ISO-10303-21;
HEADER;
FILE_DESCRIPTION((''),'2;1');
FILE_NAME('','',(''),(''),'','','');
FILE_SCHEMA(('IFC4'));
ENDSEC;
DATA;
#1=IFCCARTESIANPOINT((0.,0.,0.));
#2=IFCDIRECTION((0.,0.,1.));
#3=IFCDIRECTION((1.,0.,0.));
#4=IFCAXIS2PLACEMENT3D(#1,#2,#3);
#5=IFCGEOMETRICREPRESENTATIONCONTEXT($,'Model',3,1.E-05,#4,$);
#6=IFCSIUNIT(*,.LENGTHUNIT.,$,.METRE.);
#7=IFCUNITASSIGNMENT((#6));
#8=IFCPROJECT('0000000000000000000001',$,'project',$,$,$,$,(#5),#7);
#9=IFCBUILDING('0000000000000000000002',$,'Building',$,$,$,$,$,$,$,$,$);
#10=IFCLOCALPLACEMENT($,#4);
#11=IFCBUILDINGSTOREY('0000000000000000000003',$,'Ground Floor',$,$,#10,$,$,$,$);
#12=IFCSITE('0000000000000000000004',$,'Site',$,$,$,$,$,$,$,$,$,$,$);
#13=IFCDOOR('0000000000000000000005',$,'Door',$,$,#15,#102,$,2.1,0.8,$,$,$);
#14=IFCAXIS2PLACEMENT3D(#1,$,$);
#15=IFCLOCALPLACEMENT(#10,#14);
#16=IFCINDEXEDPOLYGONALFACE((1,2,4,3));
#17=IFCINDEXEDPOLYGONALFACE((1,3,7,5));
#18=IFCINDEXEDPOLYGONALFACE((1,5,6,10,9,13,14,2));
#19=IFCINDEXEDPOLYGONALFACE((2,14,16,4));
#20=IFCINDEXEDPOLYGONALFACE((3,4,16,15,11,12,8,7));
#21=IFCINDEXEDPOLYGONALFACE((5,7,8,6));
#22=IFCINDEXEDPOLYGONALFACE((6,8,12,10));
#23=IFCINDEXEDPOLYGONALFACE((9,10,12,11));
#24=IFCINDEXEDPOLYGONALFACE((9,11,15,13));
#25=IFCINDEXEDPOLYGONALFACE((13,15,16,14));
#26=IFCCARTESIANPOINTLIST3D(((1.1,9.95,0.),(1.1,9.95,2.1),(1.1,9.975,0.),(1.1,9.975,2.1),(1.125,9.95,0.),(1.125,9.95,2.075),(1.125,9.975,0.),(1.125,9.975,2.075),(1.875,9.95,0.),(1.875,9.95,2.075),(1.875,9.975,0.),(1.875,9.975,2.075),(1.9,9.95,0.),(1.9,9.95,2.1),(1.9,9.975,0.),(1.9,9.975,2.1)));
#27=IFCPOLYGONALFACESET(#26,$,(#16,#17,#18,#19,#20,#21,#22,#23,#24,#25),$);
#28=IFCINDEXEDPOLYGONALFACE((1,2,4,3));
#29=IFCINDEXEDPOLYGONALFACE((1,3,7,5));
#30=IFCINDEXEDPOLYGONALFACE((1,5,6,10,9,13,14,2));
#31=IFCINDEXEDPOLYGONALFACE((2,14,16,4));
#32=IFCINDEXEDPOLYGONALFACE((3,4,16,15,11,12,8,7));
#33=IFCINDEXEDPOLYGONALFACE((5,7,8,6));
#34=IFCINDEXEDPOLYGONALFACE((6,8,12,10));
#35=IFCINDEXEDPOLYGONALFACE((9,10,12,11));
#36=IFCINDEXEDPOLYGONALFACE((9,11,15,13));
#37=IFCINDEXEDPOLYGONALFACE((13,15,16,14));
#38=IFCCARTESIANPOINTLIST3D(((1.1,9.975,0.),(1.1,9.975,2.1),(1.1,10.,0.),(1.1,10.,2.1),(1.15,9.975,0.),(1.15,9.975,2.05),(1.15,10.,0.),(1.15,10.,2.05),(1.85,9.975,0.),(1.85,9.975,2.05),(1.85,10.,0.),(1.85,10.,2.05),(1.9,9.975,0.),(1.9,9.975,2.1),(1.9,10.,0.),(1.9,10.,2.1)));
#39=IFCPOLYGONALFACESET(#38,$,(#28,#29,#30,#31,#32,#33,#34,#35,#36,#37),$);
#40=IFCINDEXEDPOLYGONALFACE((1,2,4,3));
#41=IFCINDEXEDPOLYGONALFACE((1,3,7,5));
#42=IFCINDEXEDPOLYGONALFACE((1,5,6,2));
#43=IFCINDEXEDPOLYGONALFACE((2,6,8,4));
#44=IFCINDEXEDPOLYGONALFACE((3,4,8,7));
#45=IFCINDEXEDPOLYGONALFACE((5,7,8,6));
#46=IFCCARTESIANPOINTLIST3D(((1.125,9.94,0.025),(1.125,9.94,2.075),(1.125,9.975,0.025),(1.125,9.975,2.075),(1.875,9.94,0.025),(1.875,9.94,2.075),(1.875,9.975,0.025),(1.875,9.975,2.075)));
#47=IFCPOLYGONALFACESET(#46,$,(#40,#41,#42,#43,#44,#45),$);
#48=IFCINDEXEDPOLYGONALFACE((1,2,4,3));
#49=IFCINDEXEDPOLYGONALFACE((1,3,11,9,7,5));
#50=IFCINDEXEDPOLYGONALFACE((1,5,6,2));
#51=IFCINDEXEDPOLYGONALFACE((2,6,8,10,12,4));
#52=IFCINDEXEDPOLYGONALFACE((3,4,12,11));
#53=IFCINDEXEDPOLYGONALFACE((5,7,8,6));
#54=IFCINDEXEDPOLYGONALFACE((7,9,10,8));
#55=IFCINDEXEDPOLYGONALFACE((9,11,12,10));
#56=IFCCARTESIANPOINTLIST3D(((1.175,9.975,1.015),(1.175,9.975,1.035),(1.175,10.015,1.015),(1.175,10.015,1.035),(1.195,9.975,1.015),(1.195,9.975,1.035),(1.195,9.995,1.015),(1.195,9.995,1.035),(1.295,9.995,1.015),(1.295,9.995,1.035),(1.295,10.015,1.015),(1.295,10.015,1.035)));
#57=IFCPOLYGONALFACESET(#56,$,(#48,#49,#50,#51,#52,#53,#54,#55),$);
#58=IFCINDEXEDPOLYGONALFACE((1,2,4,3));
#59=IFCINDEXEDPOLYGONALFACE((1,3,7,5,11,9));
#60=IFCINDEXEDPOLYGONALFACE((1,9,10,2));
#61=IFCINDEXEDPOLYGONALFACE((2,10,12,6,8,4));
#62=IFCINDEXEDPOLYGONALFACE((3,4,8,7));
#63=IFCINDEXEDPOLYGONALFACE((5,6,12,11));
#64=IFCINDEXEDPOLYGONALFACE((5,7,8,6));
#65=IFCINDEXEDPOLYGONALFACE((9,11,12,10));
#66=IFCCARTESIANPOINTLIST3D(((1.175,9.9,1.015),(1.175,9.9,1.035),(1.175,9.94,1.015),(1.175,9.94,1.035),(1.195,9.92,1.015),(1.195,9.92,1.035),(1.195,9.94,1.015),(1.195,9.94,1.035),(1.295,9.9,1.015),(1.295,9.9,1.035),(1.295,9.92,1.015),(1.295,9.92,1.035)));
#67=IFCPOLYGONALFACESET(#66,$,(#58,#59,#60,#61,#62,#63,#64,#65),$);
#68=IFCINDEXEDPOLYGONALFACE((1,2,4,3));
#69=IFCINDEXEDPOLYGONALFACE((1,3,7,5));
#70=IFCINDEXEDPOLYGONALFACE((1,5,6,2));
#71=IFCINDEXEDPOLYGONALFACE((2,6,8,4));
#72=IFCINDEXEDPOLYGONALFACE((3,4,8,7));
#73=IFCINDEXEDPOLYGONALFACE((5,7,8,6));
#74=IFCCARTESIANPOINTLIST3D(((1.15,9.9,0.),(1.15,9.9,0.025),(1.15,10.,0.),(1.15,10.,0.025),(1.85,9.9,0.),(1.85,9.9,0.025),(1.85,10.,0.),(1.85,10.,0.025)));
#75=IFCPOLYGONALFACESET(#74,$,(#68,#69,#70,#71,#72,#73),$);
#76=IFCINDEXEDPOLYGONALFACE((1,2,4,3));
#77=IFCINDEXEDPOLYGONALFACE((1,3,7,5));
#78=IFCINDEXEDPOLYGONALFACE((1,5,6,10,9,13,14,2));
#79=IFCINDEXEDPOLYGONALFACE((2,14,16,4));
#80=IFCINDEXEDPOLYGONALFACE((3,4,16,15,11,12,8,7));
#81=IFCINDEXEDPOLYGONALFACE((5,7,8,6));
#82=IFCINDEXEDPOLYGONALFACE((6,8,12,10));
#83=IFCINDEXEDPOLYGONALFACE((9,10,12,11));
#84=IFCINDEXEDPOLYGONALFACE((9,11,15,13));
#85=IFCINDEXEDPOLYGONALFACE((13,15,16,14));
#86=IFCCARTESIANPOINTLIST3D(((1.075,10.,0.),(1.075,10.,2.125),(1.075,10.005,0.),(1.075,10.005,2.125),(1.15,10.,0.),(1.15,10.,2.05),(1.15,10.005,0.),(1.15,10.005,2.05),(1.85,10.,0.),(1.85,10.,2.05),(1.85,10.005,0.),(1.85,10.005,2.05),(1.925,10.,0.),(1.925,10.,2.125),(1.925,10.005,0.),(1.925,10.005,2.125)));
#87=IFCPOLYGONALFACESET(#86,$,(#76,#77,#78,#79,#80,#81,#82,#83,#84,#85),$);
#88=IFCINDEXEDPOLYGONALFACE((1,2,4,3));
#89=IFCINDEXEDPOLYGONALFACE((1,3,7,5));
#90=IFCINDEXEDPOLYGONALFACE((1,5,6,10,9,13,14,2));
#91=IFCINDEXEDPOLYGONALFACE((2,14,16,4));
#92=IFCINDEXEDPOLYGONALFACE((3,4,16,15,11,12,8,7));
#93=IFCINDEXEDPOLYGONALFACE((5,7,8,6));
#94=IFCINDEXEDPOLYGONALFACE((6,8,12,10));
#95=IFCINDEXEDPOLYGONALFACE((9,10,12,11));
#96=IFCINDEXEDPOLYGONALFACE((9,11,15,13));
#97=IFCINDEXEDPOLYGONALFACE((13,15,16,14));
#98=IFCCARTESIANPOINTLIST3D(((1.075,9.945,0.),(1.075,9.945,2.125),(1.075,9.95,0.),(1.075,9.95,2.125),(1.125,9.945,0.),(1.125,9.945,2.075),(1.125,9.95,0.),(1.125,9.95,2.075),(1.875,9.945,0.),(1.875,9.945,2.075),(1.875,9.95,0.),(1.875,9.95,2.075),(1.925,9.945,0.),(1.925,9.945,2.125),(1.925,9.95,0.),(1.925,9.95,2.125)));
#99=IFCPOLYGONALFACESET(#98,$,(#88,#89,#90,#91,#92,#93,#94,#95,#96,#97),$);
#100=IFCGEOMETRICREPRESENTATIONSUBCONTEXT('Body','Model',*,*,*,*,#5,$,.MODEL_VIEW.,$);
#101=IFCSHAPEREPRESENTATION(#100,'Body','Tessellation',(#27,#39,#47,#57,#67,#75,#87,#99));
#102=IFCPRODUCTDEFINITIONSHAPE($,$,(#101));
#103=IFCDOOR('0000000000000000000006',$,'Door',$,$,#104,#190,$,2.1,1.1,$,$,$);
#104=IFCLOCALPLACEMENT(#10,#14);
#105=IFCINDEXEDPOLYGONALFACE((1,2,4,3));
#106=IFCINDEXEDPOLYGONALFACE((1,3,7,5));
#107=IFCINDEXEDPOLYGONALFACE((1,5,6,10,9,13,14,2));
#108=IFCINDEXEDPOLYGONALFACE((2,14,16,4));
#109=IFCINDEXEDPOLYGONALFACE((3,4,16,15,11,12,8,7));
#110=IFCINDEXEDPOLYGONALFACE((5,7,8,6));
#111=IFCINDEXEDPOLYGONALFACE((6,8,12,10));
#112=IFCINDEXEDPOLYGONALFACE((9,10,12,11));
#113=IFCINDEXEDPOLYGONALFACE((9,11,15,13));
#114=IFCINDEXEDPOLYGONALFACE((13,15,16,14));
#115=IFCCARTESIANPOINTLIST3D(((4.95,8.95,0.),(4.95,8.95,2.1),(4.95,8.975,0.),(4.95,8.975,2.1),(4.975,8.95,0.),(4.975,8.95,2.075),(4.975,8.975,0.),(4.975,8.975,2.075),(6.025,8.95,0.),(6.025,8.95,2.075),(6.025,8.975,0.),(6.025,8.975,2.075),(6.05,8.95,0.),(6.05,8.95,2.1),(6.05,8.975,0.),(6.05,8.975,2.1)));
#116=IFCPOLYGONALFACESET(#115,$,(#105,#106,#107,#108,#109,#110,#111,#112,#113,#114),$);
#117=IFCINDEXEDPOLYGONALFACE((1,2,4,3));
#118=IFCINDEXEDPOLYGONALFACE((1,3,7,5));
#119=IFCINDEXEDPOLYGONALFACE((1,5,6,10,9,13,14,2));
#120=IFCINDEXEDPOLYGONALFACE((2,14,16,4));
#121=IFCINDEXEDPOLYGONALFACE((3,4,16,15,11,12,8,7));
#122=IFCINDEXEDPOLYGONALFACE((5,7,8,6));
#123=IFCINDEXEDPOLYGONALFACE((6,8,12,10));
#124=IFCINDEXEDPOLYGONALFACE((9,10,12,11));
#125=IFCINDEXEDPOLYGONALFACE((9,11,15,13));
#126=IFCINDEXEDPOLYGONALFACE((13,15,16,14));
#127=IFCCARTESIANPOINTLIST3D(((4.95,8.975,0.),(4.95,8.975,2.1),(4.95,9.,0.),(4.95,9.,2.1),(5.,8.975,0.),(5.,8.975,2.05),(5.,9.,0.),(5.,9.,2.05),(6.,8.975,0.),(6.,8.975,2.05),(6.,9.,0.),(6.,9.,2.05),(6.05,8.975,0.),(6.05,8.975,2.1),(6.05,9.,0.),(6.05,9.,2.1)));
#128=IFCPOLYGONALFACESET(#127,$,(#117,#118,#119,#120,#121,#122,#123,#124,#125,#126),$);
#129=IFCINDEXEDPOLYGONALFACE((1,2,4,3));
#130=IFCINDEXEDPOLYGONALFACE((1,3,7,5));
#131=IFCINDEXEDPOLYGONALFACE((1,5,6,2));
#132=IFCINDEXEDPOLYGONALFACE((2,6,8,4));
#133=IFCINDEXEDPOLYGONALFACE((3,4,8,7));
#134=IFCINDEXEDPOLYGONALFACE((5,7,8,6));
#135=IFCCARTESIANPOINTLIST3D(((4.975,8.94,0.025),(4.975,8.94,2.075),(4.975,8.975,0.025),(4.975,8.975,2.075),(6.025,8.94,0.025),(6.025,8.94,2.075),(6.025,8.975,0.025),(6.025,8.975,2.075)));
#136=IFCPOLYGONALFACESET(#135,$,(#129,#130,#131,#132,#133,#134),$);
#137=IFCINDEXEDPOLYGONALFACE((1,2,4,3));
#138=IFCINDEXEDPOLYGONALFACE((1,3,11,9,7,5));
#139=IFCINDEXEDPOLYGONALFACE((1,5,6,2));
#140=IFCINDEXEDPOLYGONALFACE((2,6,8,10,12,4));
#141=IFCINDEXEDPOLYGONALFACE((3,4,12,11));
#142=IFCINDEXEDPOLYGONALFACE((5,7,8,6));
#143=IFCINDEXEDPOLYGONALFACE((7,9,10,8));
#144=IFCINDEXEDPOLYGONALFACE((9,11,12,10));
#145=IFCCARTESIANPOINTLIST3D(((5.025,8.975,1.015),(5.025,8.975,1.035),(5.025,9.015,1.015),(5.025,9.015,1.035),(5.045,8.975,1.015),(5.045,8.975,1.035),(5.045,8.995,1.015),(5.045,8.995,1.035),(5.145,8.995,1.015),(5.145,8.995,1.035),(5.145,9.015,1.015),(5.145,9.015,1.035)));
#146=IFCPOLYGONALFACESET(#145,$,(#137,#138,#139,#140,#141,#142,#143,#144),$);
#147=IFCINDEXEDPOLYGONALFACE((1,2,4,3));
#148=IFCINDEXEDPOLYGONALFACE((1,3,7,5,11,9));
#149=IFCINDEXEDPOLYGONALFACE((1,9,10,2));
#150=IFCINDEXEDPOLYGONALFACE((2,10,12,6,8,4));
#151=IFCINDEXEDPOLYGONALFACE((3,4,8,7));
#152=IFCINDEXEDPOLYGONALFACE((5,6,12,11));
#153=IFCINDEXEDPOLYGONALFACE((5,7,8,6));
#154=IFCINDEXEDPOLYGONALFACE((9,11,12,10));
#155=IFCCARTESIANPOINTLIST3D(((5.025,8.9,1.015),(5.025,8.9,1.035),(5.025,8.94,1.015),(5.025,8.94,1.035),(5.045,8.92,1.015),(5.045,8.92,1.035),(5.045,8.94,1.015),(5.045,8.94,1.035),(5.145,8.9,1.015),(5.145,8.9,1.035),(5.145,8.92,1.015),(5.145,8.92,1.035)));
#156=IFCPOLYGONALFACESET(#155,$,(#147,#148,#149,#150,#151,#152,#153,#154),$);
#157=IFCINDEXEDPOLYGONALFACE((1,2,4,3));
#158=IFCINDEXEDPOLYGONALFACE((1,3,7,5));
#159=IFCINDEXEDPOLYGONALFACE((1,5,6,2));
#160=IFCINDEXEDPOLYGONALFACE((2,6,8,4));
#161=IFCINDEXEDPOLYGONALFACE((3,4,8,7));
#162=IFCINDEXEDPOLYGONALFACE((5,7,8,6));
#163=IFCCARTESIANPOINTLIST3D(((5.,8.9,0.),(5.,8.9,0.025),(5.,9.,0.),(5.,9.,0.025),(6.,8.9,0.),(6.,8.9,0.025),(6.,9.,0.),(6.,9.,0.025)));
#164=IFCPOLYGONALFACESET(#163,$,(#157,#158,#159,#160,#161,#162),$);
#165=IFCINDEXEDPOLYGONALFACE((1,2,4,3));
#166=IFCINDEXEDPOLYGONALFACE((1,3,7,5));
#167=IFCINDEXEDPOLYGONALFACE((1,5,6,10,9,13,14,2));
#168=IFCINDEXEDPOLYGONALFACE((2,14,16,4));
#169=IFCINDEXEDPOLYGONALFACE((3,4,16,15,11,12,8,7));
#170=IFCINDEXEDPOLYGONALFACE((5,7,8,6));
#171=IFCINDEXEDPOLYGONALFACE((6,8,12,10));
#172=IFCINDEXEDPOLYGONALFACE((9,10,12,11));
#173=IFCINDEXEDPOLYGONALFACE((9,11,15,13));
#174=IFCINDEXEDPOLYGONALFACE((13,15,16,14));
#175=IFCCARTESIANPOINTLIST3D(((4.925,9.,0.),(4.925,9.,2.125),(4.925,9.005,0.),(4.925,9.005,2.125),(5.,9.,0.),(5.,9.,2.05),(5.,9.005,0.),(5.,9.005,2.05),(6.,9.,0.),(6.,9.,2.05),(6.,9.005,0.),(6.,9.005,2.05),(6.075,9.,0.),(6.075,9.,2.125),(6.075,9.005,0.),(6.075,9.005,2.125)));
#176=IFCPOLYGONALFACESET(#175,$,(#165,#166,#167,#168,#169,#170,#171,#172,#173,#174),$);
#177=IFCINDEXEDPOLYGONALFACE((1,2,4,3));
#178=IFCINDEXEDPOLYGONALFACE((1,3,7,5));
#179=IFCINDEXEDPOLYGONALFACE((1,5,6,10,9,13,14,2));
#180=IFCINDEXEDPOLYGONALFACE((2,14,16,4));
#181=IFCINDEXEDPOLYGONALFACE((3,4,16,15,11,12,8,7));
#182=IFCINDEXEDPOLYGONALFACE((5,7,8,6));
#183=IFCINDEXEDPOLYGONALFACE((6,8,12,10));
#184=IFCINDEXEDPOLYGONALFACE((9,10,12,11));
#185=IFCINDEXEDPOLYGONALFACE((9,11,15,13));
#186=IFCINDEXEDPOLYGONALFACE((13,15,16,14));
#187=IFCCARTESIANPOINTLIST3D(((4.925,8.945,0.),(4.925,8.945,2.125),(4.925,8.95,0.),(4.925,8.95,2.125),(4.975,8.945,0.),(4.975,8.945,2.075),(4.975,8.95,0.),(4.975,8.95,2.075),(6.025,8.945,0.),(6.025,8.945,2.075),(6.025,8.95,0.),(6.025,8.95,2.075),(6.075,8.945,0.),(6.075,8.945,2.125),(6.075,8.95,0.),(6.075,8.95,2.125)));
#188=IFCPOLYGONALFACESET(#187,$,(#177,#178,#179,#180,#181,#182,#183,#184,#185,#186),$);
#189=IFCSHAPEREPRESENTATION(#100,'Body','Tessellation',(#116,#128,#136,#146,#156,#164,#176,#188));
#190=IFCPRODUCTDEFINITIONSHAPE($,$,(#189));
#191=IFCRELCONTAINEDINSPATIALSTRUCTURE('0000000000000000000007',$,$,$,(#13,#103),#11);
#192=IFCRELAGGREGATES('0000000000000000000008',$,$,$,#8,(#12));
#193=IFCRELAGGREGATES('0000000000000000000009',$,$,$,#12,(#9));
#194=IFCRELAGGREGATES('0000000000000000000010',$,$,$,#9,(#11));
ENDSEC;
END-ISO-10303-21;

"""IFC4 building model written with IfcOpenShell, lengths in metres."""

from ifc_helpers import new_model, si_unit, frame, origin_with_axes, place, context, subcontext, project, spatial, line, indexed_curve, outline, extrude, element, save


model = new_model("IFC4")

# Units and contexts
model_context = context("Model", 3, precision=1e-05, world=origin_with_axes())
body_context = subcontext(model_context, "Body", "Model", "MODEL_VIEW")
ifc_project = project(units=[si_unit("LENGTHUNIT", "METRE")], contexts=[model_context])

# Site, building, storey
site = spatial("IfcSite", under=ifc_project, Name="Site")
building = spatial("IfcBuilding", under=site, Name="Building")
storey_placement = place(None, origin_with_axes())
storey = spatial("IfcBuildingStorey", under=building, at=storey_placement, Name="Ground Floor")

# Doors
door_1_placement = place(storey_placement, frame((1.9, 10.0, 0.0), z_axis=(0.0, 0.0, 1.0), x_axis=(-1.0, 0.0, 0.0)))
element("IfcDoor", 1, at=door_1_placement, inside=storey, Name="Door", OverallHeight=2.1, OverallWidth=0.8, context=body_context, shape_type="SweptSolid", body=[
    extrude(outline(indexed_curve([(0.0, 0.0), (0.0, 2.1), (0.8, 2.1), (0.8, 0.0), (0.775, 0.0), (0.775, 2.075), (0.025, 2.075), (0.025, 0.0)], segments=[line(1, 2, 3, 4, 5, 6, 7, 8, 1)])), frame((0.0, 0.025, 0.0), z_axis=(0.0, -1.0, 0.0), x_axis=(1.0, 0.0, 0.0)), (0.0, 0.0, -1.0), 0.025),
    extrude(outline(indexed_curve([(0.0, 0.0), (0.0, 2.1), (0.8, 2.1), (0.8, 0.0), (0.75, 0.0), (0.75, 2.05), (0.05, 2.05), (0.05, 0.0)], segments=[line(1, 2, 3, 4, 5, 6, 7, 8, 1)])), frame((0.0, 0.0, 0.0), z_axis=(0.0, -1.0, 0.0), x_axis=(1.0, 0.0, 0.0)), (0.0, 0.0, -1.0), 0.025),
    extrude(outline(indexed_curve([(0.0, 0.0), (0.75, 0.0), (0.75, 0.035), (0.0, 0.035)], segments=[line(1, 2, 3, 4, 1)])), frame((0.025, 0.025, 0.025), z_axis=(0.0, 0.0, 1.0), x_axis=(1.0, 0.0, 0.0)), (0.0, 0.0, 1.0), 2.05),
    extrude(outline(indexed_curve([(0.0, 0.0), (0.0, -0.04), (-0.12, -0.04), (-0.12, -0.02), (-0.02, -0.02), (-0.02, 0.0)], segments=[line(1, 2, 3, 4, 5, 6, 1)])), frame((0.725, 0.025, 1.015), z_axis=(0.0, 0.0, 1.0), x_axis=(1.0, 0.0, 0.0)), (0.0, 0.0, 1.0), 0.02),
    extrude(outline(indexed_curve([(0.0, 0.0), (0.0, 0.04), (-0.12, 0.04), (-0.12, 0.02), (-0.02, 0.02), (-0.02, 0.0)], segments=[line(1, 2, 3, 4, 5, 6, 1)])), frame((0.725, 0.06, 1.015), z_axis=(0.0, 0.0, 1.0), x_axis=(1.0, 0.0, 0.0)), (0.0, 0.0, 1.0), 0.02),
    extrude(outline(indexed_curve([(0.0, 0.0), (0.7, 0.0), (0.7, 0.1), (0.0, 0.1)], segments=[line(1, 2, 3, 4, 1)])), frame((0.05, 0.0, 0.0), z_axis=(0.0, 0.0, 1.0), x_axis=(1.0, 0.0, 0.0)), (0.0, 0.0, 1.0), 0.025),
    extrude(outline(indexed_curve([(0.0, 0.0), (0.0, 2.125), (0.85, 2.125), (0.85, 0.0), (0.775, 0.0), (0.775, 2.05), (0.075, 2.05), (0.075, 0.0)], segments=[line(1, 2, 3, 4, 5, 6, 7, 8, 1)])), frame((-0.025, -0.005, 0.0), z_axis=(0.0, -1.0, 0.0), x_axis=(1.0, 0.0, 0.0)), (0.0, 0.0, -1.0), 0.005),
    extrude(outline(indexed_curve([(0.0, 0.0), (0.0, 2.125), (0.85, 2.125), (0.85, 0.0), (0.8, 0.0), (0.8, 2.075), (0.05, 2.075), (0.05, 0.0)], segments=[line(1, 2, 3, 4, 5, 6, 7, 8, 1)])), frame((-0.025, 0.05, 0.0), z_axis=(0.0, -1.0, 0.0), x_axis=(1.0, 0.0, 0.0)), (0.0, 0.0, -1.0), 0.005),
])
door_2_placement = place(storey_placement, frame((6.05, 9.0, 0.0), z_axis=(0.0, 0.0, 1.0), x_axis=(-1.0, 0.0, 0.0)))
element("IfcDoor", 2, at=door_2_placement, inside=storey, Name="Door", OverallHeight=2.1, OverallWidth=1.1, context=body_context, shape_type="SweptSolid", body=[
    extrude(outline(indexed_curve([(0.0, 0.0), (0.0, 2.1), (1.1, 2.1), (1.1, 0.0), (1.075, 0.0), (1.075, 2.075), (0.025, 2.075), (0.025, 0.0)], segments=[line(1, 2, 3, 4, 5, 6, 7, 8, 1)])), frame((0.0, 0.025, 0.0), z_axis=(0.0, -1.0, 0.0), x_axis=(1.0, 0.0, 0.0)), (0.0, 0.0, -1.0), 0.025),
    extrude(outline(indexed_curve([(0.0, 0.0), (0.0, 2.1), (1.1, 2.1), (1.1, 0.0), (1.05, 0.0), (1.05, 2.05), (0.05, 2.05), (0.05, 0.0)], segments=[line(1, 2, 3, 4, 5, 6, 7, 8, 1)])), frame((0.0, 0.0, 0.0), z_axis=(0.0, -1.0, 0.0), x_axis=(1.0, 0.0, 0.0)), (0.0, 0.0, -1.0), 0.025),
    extrude(outline(indexed_curve([(0.0, 0.0), (1.05, 0.0), (1.05, 0.035), (0.0, 0.035)], segments=[line(1, 2, 3, 4, 1)])), frame((0.025, 0.025, 0.025), z_axis=(0.0, 0.0, 1.0), x_axis=(1.0, 0.0, 0.0)), (0.0, 0.0, 1.0), 2.05),
    extrude(outline(indexed_curve([(0.0, 0.0), (0.0, -0.04), (-0.12, -0.04), (-0.12, -0.02), (-0.02, -0.02), (-0.02, 0.0)], segments=[line(1, 2, 3, 4, 5, 6, 1)])), frame((1.025, 0.025, 1.015), z_axis=(0.0, 0.0, 1.0), x_axis=(1.0, 0.0, 0.0)), (0.0, 0.0, 1.0), 0.02),
    extrude(outline(indexed_curve([(0.0, 0.0), (0.0, 0.04), (-0.12, 0.04), (-0.12, 0.02), (-0.02, 0.02), (-0.02, 0.0)], segments=[line(1, 2, 3, 4, 5, 6, 1)])), frame((1.025, 0.06, 1.015), z_axis=(0.0, 0.0, 1.0), x_axis=(1.0, 0.0, 0.0)), (0.0, 0.0, 1.0), 0.02),
    extrude(outline(indexed_curve([(0.0, 0.0), (1.0, 0.0), (1.0, 0.1), (0.0, 0.1)], segments=[line(1, 2, 3, 4, 1)])), frame((0.05, 0.0, 0.0), z_axis=(0.0, 0.0, 1.0), x_axis=(1.0, 0.0, 0.0)), (0.0, 0.0, 1.0), 0.025),
    extrude(outline(indexed_curve([(0.0, 0.0), (0.0, 2.125), (1.15, 2.125), (1.15, 0.0), (1.075, 0.0), (1.075, 2.05), (0.075, 2.05), (0.075, 0.0)], segments=[line(1, 2, 3, 4, 5, 6, 7, 8, 1)])), frame((-0.025, -0.005, 0.0), z_axis=(0.0, -1.0, 0.0), x_axis=(1.0, 0.0, 0.0)), (0.0, 0.0, -1.0), 0.005),
    extrude(outline(indexed_curve([(0.0, 0.0), (0.0, 2.125), (1.15, 2.125), (1.15, 0.0), (1.1, 0.0), (1.1, 2.075), (0.05, 2.075), (0.05, 0.0)], segments=[line(1, 2, 3, 4, 5, 6, 7, 8, 1)])), frame((-0.025, 0.05, 0.0), z_axis=(0.0, -1.0, 0.0), x_axis=(1.0, 0.0, 0.0)), (0.0, 0.0, -1.0), 0.005),
])

save(model, "model.ifc")
